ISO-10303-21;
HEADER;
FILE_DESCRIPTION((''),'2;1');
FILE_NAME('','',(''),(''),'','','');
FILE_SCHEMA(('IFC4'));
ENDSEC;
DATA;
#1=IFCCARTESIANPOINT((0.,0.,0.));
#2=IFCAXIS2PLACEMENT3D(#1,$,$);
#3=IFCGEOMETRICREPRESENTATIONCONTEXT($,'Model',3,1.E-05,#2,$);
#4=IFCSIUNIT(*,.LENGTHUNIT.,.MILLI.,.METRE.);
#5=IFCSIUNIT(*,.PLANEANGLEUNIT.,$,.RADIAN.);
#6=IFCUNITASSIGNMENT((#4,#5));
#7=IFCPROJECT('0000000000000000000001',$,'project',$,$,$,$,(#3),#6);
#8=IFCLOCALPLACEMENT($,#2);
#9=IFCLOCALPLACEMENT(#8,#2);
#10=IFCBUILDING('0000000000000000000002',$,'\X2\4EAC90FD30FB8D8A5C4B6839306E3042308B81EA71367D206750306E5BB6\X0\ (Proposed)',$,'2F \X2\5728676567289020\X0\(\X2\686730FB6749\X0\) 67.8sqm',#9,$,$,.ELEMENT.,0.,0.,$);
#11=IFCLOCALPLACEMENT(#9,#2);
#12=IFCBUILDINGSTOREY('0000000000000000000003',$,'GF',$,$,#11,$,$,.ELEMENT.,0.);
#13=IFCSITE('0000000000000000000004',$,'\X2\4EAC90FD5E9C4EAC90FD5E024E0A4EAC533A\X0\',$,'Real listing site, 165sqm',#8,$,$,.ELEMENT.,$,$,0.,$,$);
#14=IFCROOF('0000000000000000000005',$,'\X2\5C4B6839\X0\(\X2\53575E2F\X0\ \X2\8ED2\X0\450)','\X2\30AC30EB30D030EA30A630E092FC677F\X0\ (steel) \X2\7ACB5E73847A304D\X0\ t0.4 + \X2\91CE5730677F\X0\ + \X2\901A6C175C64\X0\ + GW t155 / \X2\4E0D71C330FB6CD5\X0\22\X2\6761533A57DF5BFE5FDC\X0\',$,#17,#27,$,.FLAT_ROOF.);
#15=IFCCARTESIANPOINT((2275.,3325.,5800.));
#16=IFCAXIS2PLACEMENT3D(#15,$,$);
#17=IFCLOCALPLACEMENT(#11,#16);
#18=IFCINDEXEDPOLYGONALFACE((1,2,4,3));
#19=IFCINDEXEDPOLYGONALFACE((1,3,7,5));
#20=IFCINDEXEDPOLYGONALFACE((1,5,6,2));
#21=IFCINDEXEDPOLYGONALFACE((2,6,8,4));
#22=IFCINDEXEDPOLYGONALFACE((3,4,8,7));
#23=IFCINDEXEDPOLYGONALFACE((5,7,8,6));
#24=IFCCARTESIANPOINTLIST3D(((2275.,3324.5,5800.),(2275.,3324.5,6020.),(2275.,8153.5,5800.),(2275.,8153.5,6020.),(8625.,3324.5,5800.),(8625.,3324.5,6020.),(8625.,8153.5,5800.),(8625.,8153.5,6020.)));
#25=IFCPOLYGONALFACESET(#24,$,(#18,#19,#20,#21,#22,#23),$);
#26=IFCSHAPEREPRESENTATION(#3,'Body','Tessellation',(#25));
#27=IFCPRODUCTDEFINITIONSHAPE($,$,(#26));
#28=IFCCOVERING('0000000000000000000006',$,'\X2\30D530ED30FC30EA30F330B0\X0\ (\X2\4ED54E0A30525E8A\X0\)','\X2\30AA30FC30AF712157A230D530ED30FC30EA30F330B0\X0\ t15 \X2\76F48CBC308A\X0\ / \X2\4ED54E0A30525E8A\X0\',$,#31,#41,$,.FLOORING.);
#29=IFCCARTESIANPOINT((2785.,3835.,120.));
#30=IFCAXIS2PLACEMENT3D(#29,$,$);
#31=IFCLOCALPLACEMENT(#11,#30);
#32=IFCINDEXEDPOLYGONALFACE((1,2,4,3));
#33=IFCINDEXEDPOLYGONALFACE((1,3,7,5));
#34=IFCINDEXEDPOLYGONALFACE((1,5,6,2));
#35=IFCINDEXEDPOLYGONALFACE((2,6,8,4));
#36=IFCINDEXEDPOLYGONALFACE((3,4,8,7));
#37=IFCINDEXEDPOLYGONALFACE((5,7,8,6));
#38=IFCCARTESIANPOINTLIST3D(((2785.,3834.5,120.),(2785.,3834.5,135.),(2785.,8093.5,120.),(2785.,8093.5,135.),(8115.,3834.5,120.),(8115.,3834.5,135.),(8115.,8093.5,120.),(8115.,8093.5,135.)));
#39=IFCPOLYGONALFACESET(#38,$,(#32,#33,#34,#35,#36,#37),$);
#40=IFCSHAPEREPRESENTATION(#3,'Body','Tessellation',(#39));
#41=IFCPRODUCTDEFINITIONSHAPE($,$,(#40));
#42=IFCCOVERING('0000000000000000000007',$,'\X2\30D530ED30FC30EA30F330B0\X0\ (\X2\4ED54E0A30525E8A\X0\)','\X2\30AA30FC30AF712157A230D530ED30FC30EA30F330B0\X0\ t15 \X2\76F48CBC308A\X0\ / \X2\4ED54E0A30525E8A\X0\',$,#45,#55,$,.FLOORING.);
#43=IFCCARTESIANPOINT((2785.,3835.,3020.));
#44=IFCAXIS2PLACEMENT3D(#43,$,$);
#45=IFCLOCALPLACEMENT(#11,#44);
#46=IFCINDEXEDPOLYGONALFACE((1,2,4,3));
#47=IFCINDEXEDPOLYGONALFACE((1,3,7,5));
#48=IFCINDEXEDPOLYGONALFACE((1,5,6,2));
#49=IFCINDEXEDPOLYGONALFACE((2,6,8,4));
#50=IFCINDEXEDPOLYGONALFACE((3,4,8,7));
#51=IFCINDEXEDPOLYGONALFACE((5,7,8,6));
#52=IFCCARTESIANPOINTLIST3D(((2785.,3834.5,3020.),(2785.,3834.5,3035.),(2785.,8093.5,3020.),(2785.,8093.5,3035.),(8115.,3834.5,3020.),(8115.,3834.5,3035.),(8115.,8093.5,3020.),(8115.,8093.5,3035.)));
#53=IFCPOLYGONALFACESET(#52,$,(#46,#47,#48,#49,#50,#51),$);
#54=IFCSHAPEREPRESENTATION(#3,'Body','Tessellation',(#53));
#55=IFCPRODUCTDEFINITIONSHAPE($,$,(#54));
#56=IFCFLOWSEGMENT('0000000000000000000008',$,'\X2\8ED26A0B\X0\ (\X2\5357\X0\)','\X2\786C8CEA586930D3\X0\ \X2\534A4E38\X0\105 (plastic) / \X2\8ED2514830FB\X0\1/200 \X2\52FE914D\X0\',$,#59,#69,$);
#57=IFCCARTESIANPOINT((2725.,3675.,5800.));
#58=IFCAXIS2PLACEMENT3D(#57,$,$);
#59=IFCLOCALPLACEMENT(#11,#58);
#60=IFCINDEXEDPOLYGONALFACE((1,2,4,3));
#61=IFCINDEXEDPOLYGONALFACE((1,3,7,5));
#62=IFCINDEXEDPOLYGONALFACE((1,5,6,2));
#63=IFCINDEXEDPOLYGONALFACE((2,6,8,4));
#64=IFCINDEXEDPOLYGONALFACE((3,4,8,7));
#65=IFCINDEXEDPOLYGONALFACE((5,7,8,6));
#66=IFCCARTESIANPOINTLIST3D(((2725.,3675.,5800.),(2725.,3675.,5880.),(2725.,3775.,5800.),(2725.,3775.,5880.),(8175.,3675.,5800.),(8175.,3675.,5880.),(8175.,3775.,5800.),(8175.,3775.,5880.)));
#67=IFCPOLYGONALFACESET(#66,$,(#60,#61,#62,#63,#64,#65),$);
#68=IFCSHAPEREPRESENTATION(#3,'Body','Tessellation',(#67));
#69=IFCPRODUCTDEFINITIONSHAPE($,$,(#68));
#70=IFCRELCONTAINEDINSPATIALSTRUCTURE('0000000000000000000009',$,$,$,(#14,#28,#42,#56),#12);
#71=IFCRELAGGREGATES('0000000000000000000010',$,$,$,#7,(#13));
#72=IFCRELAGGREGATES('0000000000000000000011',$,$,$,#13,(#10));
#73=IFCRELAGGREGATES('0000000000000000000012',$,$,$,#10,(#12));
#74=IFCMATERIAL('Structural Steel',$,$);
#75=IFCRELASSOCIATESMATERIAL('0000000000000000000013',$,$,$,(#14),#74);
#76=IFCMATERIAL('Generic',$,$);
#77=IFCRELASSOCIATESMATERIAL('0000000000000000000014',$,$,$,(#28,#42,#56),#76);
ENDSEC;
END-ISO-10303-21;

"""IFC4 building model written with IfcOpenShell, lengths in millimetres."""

from ifc_helpers import new_model, si_unit, frame, frame_2d, origin, place, context, project, spatial, rectangle, extrude, material, element, save


model = new_model("IFC4")

# Units and contexts
model_context = context("Model", 3, precision=1e-05, world=origin())
ifc_project = project(units=[si_unit("LENGTHUNIT", "METRE", prefix="MILLI"), si_unit("PLANEANGLEUNIT", "RADIAN")], contexts=[model_context])

# Site, building, storey
site_placement = place(None, origin())
site = spatial("IfcSite", under=ifc_project, at=site_placement, Name="京都府京都市上京区", ObjectType="Real listing site, 165sqm", CompositionType="ELEMENT", RefElevation=0.0)
building_placement = place(site_placement, origin())
building = spatial("IfcBuilding", under=site, at=building_placement, Name="京都・越屋根のある自然素材の家 (Proposed)", ObjectType="2F 在来木造(桧・杉) 67.8sqm", CompositionType="ELEMENT", ElevationOfRefHeight=0.0, ElevationOfTerrain=0.0)
storey_placement = place(building_placement, origin())
storey = spatial("IfcBuildingStorey", under=building, at=storey_placement, Name="GF", CompositionType="ELEMENT", Elevation=0.0)

# Roof
ifc_material_1 = material(Name="Structural Steel")
for number, where, name in (
    (1, (2275.0, 3325.0, 5800.0), "屋根(南帯 軒450)"),
):
    element("IfcRoof", number, at=place(storey_placement, frame(where)), inside=storey, material=ifc_material_1, Name=name, Description="ガルバリウム鋼板 (steel) 立平葺き t0.4 + 野地板 + 通気層 + GW t155 / 不燃・法22条区域対応", PredefinedType="FLAT_ROOF", context=model_context, shape_type="SweptSolid", body=[
        extrude(rectangle(XDim=6350.0, YDim=4829.0, at=frame_2d((3175.0, 2414.0))), frame((2275.0, 3325.0, 5800.0)), (0.0, 0.0, 1.0), 220.0),
    ])

# Coverings
ifc_material_2 = material(Name="Generic")
covering_1_placement = place(storey_placement, frame((2785.0, 3835.0, 120.0)))
element("IfcCovering", 2, at=covering_1_placement, inside=storey, material=ifc_material_2, Name="フローリング (仕上げ床)", Description="オーク無垢フローリング t15 直貼り / 仕上げ床", PredefinedType="FLOORING", context=model_context, shape_type="SweptSolid", body=[
    extrude(rectangle(XDim=5330.0, YDim=4259.0, at=frame_2d((2665.0, 2129.0))), frame((2785.0, 3835.0, 120.0)), (0.0, 0.0, 1.0), 15.0),
])
covering_2_placement = place(storey_placement, frame((2785.0, 3835.0, 3020.0)))
element("IfcCovering", 3, at=covering_2_placement, inside=storey, material=ifc_material_2, Name="フローリング (仕上げ床)", Description="オーク無垢フローリング t15 直貼り / 仕上げ床", PredefinedType="FLOORING", context=model_context, shape_type="SweptSolid", body=[
    extrude(rectangle(XDim=5330.0, YDim=4259.0, at=frame_2d((2665.0, 2129.0))), frame((2785.0, 3835.0, 3020.0)), (0.0, 0.0, 1.0), 15.0),
])

# Flow segment
flow_segment_placement = place(storey_placement, frame((2725.0, 3675.0, 5800.0)))
element("IfcFlowSegment", 4, at=flow_segment_placement, inside=storey, material=ifc_material_2, Name="軒樋 (南)", Description="硬質塩ビ 半丸105 (plastic) / 軒先・1/200 勾配", context=model_context, shape_type="SweptSolid", body=[
    extrude(rectangle(XDim=5450.0, YDim=100.0, at=frame_2d((2725.0, 50.0))), frame((2725.0, 3675.0, 5800.0)), (0.0, 0.0, 1.0), 80.0),
])

save(model, "model.ifc")
